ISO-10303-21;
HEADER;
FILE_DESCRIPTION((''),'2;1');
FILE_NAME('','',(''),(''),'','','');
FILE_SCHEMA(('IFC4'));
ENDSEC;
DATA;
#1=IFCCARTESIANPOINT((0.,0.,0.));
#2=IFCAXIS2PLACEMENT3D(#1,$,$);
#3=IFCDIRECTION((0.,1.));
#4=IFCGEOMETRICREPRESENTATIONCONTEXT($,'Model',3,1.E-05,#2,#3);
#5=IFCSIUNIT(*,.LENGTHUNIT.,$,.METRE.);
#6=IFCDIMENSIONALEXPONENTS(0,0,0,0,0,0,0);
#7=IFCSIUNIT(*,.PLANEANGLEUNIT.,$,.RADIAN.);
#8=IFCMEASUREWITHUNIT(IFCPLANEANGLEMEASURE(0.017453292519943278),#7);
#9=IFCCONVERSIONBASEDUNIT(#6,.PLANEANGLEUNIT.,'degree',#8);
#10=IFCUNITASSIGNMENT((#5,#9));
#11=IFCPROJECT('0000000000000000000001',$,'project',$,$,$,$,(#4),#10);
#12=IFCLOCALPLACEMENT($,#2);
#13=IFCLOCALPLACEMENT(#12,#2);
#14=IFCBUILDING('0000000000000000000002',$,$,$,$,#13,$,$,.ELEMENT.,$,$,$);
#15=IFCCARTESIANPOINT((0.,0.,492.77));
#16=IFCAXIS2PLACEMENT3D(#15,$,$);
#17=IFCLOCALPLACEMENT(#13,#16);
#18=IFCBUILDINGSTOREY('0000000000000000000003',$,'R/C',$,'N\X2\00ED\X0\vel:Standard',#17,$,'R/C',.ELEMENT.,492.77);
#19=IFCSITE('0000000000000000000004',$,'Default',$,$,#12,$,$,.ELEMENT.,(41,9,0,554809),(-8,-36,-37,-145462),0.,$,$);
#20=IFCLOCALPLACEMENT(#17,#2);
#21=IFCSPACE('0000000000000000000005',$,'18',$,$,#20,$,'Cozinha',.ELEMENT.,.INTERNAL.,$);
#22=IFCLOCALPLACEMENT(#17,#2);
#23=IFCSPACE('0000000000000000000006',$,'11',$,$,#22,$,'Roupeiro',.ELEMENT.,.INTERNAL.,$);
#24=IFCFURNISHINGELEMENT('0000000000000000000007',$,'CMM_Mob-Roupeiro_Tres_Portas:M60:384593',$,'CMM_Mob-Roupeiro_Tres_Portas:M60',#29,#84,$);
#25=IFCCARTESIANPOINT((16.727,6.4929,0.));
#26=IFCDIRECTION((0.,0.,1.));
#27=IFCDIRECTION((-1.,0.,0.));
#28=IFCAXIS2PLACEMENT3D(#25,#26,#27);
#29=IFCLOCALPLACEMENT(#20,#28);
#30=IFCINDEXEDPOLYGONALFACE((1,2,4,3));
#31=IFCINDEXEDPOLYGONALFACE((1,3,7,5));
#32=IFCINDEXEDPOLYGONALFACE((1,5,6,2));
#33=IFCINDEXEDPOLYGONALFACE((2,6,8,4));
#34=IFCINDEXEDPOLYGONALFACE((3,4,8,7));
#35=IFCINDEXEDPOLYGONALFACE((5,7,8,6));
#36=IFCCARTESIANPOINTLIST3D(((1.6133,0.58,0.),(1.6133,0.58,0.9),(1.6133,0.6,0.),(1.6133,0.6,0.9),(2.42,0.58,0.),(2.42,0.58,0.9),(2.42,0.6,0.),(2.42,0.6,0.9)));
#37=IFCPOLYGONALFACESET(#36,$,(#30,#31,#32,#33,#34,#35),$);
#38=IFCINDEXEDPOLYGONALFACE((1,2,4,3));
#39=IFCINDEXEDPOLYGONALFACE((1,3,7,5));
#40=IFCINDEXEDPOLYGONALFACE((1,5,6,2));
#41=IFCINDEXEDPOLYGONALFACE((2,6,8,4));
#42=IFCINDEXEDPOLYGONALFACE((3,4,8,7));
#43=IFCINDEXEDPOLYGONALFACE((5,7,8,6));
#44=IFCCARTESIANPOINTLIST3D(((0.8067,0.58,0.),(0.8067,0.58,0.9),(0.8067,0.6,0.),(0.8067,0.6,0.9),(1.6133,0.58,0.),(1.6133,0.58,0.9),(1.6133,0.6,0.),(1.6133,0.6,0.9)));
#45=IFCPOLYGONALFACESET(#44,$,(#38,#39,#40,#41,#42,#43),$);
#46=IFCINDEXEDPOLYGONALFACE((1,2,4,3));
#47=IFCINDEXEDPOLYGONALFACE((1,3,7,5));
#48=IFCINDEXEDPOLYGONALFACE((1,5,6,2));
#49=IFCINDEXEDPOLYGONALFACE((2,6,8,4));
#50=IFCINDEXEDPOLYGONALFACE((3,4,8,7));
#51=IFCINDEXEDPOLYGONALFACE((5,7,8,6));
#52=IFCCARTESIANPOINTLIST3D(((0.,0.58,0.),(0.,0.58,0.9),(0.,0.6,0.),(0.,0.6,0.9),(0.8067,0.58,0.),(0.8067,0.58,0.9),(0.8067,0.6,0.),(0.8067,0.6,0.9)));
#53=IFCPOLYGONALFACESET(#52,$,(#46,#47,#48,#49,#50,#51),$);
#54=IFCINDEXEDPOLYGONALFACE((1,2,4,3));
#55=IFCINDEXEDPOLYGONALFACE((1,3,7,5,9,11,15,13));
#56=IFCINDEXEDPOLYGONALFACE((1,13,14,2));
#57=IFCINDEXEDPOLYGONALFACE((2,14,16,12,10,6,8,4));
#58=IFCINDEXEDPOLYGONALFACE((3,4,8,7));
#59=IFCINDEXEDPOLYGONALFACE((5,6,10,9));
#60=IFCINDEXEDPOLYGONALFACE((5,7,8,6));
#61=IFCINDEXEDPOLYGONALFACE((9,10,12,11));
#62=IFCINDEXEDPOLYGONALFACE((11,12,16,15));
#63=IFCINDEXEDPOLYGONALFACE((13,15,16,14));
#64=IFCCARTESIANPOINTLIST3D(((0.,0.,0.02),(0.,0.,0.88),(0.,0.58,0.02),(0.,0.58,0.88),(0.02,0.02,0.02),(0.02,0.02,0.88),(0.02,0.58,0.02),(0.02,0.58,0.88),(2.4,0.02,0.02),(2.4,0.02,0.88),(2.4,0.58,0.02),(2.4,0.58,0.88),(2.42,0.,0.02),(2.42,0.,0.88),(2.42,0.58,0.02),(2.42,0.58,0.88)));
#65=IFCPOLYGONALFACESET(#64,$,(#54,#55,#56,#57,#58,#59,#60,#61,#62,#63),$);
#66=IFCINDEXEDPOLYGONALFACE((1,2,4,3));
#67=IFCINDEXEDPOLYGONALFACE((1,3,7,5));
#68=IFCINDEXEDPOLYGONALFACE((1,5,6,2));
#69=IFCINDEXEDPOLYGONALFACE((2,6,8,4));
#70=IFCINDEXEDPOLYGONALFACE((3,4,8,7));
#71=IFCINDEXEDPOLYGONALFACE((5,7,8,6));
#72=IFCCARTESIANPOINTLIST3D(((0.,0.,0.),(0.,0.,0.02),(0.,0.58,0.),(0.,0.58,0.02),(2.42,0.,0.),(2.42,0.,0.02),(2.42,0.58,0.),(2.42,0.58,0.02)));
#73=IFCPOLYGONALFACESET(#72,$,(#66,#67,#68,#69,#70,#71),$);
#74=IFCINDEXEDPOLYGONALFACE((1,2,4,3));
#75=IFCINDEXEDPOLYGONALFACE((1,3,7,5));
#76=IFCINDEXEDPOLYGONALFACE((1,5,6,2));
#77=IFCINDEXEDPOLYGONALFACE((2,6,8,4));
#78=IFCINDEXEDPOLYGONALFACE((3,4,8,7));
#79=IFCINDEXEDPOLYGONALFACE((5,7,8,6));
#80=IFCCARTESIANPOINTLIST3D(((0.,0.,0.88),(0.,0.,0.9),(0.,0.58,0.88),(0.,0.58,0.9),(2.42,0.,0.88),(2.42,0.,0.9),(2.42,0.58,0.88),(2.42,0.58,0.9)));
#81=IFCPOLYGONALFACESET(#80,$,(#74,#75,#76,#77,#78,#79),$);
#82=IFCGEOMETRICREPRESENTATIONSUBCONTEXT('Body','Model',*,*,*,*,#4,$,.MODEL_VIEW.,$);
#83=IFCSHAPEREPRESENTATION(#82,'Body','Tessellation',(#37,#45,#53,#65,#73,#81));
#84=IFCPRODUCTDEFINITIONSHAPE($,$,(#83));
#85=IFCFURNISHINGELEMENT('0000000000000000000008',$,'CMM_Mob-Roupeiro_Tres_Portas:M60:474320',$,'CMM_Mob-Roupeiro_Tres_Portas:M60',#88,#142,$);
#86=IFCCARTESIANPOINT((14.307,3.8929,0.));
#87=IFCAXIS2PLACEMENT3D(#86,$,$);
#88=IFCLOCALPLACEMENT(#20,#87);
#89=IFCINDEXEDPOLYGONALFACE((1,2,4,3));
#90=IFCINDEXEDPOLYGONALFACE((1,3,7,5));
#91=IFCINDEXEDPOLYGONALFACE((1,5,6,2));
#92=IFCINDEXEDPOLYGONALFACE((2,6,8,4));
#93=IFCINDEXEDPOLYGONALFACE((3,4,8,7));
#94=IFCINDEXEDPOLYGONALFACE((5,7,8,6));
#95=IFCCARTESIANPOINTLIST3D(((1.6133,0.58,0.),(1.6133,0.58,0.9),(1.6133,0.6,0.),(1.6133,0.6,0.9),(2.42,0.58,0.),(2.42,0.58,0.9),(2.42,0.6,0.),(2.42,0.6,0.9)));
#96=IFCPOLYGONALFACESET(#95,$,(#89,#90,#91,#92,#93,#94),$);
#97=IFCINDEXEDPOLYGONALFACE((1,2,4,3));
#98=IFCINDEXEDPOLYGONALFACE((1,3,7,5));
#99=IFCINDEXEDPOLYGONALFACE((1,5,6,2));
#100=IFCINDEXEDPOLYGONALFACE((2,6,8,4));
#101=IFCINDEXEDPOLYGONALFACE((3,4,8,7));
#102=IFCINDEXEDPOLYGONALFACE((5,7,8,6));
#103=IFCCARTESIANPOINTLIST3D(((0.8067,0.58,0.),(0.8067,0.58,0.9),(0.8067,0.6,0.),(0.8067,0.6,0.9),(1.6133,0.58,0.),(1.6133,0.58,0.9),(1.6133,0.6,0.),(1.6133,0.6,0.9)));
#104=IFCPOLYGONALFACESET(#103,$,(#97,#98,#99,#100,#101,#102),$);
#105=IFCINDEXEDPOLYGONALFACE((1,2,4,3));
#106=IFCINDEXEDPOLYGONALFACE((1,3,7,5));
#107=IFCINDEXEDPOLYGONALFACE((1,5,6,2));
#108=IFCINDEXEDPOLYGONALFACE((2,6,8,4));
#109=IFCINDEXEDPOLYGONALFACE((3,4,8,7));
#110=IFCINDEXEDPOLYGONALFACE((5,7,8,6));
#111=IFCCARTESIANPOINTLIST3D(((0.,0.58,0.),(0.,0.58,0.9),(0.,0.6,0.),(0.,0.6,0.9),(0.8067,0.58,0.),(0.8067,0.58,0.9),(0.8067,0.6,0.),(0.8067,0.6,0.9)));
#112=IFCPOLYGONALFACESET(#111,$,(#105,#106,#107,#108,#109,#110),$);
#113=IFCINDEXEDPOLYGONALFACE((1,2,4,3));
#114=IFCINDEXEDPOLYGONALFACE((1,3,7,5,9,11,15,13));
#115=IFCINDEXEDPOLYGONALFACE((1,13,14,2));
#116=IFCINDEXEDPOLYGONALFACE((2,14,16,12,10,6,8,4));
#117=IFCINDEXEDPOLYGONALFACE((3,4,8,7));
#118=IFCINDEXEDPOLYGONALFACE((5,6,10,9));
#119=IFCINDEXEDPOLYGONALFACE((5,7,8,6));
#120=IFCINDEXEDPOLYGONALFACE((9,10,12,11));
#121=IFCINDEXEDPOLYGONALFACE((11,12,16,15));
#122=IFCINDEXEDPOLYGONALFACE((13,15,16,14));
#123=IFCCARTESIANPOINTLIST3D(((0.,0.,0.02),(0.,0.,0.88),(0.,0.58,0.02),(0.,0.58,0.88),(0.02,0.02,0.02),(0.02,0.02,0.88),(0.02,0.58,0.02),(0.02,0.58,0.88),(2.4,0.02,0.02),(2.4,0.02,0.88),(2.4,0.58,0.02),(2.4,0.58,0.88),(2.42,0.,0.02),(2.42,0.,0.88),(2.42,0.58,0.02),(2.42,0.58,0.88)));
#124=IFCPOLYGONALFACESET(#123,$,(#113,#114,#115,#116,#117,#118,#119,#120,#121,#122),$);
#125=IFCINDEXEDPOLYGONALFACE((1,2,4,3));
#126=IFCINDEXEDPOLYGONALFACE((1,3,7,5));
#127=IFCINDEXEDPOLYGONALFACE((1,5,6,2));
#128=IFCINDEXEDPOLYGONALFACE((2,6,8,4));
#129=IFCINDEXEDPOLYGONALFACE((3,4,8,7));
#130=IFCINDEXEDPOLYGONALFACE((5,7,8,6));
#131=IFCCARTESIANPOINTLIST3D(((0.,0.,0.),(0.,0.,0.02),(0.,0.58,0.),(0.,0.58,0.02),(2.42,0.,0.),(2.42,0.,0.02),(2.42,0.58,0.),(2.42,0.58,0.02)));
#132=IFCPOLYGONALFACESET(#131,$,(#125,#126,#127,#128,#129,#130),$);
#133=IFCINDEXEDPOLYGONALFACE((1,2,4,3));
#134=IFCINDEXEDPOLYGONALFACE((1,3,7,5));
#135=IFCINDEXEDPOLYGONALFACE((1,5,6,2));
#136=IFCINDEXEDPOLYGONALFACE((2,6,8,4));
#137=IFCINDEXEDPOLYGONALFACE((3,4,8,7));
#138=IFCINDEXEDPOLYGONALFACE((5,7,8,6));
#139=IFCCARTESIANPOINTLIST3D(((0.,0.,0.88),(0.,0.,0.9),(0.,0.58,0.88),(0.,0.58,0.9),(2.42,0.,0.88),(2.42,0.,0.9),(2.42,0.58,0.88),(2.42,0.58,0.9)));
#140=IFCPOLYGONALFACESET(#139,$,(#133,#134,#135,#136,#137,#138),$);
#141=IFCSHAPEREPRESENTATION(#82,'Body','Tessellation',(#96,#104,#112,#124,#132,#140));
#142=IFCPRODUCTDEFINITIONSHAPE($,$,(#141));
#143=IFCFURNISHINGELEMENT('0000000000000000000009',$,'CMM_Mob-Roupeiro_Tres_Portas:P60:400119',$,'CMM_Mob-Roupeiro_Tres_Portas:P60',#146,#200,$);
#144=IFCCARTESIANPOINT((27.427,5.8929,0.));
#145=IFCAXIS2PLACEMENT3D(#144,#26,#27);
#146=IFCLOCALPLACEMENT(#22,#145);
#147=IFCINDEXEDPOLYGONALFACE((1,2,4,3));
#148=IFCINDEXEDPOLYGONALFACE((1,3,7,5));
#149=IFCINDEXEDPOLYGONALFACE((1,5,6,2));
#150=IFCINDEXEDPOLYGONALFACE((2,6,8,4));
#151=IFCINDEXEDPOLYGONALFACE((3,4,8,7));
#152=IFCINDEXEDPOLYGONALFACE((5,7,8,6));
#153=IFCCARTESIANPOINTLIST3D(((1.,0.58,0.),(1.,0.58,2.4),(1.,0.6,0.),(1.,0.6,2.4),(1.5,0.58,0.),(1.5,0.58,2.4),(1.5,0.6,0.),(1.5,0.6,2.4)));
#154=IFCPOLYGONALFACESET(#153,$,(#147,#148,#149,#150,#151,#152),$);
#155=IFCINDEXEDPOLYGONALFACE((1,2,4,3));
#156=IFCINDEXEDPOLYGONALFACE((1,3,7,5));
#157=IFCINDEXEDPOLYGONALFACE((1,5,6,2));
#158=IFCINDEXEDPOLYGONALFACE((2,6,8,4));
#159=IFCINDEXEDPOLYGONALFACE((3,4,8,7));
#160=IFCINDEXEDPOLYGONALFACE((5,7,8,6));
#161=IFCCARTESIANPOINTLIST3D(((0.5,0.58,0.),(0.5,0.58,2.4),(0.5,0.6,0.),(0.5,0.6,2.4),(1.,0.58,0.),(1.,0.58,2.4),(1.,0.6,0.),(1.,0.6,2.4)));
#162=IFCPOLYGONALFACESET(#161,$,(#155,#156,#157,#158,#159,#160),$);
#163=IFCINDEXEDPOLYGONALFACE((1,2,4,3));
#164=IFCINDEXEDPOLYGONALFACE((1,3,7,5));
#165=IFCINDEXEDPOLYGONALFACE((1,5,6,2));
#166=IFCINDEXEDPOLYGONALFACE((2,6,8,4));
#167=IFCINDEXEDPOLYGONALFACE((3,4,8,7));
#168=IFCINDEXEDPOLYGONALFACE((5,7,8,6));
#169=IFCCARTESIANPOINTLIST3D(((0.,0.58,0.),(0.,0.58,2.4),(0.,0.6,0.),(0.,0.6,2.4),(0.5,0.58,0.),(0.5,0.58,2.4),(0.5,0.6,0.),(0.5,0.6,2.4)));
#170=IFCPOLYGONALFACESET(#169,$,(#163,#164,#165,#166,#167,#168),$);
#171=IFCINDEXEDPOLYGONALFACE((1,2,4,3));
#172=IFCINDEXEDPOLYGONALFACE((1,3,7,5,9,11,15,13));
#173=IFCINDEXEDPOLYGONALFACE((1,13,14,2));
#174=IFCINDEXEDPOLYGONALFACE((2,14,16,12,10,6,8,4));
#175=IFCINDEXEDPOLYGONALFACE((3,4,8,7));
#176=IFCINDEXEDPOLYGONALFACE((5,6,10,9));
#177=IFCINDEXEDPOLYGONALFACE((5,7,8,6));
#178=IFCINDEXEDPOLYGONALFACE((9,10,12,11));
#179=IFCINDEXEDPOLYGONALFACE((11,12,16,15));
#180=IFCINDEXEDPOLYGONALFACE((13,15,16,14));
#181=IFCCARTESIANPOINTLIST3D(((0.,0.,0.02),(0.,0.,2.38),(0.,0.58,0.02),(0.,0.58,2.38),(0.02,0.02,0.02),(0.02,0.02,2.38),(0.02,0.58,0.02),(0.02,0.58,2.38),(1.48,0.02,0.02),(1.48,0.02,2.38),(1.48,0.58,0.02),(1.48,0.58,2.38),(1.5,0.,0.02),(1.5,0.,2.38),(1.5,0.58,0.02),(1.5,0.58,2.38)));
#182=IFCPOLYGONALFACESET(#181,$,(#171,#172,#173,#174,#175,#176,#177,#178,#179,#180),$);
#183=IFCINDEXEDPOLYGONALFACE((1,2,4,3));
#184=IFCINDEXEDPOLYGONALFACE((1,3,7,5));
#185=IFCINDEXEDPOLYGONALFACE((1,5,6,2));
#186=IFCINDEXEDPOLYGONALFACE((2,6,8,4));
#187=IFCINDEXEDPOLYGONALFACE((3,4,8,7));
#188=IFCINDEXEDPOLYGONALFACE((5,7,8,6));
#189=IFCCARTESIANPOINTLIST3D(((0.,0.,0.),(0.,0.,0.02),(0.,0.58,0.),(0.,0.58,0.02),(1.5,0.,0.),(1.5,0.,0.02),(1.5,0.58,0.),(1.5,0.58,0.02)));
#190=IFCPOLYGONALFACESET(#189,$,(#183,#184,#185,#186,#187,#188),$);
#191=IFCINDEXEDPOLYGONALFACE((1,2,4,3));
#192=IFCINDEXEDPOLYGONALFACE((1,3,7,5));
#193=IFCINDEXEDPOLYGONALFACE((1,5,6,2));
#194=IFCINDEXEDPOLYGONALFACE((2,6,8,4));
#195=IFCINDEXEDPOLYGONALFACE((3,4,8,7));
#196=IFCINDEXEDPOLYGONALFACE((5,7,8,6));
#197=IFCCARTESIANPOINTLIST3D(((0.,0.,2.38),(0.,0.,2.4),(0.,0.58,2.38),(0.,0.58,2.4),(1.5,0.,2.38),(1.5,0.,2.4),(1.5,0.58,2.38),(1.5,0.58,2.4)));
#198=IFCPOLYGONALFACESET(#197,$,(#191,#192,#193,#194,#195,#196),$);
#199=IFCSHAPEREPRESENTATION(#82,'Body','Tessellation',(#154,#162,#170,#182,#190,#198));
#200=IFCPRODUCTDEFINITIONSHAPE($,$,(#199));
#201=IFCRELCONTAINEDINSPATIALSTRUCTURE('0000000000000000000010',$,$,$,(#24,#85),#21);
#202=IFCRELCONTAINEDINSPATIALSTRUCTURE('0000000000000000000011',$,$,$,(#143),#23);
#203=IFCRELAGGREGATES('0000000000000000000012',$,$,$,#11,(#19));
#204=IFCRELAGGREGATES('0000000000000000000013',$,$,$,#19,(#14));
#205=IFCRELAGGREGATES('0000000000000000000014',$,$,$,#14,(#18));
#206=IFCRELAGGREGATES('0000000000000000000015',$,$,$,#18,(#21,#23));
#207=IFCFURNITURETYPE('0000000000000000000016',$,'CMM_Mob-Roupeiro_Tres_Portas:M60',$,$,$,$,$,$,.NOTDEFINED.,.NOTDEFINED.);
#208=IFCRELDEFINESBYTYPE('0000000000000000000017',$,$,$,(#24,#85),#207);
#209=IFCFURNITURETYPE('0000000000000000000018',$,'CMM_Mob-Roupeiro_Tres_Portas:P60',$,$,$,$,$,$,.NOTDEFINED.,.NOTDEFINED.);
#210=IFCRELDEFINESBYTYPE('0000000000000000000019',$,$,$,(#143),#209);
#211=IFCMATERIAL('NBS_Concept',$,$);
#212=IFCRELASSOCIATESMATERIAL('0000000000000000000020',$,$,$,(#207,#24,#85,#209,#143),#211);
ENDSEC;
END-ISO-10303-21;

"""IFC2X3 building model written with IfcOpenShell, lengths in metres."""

from ifc_helpers import new_model, entity, si_unit, converted_unit, direction, frame, frame_2d, origin, place, context, subcontext, project, spatial, polyline, rectangle, outline, extrude, source, transform, mapped, material, type_object, type_shapes, element, save


model = new_model("IFC2X3")

# Units and contexts
model_context = context("Model", 3, precision=1e-05, world=origin(), true_north=direction((0.0, 1.0)))
body_context = subcontext(model_context, "Body", "Model", "MODEL_VIEW")
ifc_project = project(units=[si_unit("LENGTHUNIT", "METRE"), converted_unit("PLANEANGLEUNIT", "degree", entity("IfcPlaneAngleMeasure", 0.017453292519943278), si_unit("PLANEANGLEUNIT", "RADIAN"), dimensions=[0, 0, 0, 0, 0, 0, 0])], contexts=[model_context])

# Site, building, storey
site_placement = place(None, origin())
site = spatial("IfcSite", under=ifc_project, at=site_placement, Name="Default", CompositionType="ELEMENT", RefLatitude=(41, 9, 0, 554809), RefLongitude=(-8, -36, -37, -145462), RefElevation=0.0)
building_placement = place(site_placement, origin())
building = spatial("IfcBuilding", under=site, at=building_placement, CompositionType="ELEMENT")
storey_placement = place(building_placement, frame((0.0, 0.0, 492.77)))
storey = spatial("IfcBuildingStorey", under=building, at=storey_placement, Name="R/C", ObjectType="Nível:Standard", LongName="R/C", CompositionType="ELEMENT", Elevation=492.77)

# Shared definitions
space_1_placement = place(storey_placement, origin())
space_1 = spatial("IfcSpace", under=storey, at=space_1_placement, Name="18", LongName="Cozinha", CompositionType="ELEMENT", InteriorOrExteriorSpace="INTERNAL")

# Furnishing elements
ifc_material_1 = material(Name="NBS_Concept")
furniture_type_1 = type_object("IfcFurnitureType", Name="CMM_Mob-Roupeiro_Tres_Portas:M60", AssemblyPlace="NOTDEFINED", material=ifc_material_1)
shared_shape_1 = source(origin(), body_context, "Body", "SweptSolid", [
    extrude(rectangle(XDim=0.8067, YDim=0.02, at=frame_2d((0.0, 0.0), x_axis=(1.0, 0.0))), frame((2.0167, 0.59, 0.0), z_axis=(0.0, 0.0, 1.0), x_axis=(-1.0, 0.0, 0.0)), (0.0, 0.0, 1.0), 0.9),
    extrude(rectangle(XDim=0.8067, YDim=0.02, at=frame_2d((0.0, 0.0), x_axis=(1.0, 0.0))), frame((1.21, 0.59, 0.0), z_axis=(0.0, 0.0, 1.0), x_axis=(-1.0, 0.0, 0.0)), (0.0, 0.0, 1.0), 0.9),
    extrude(rectangle(XDim=0.8067, YDim=0.02, at=frame_2d((0.0, 0.0), x_axis=(1.0, 0.0))), frame((0.4033, 0.59, 0.0), z_axis=(0.0, 0.0, 1.0), x_axis=(-1.0, 0.0, 0.0)), (0.0, 0.0, 1.0), 0.9),
    extrude(outline(polyline([(-1.21, -0.295), (1.21, -0.295), (1.21, 0.285), (1.19, 0.285), (1.19, -0.275), (-1.19, -0.275), (-1.19, 0.285), (-1.21, 0.285), (-1.21, -0.295)])), frame((1.21, 0.295, 0.02)), (0.0, 0.0, 1.0), 0.86),
    extrude(rectangle(XDim=2.42, YDim=0.58, at=frame_2d((0.0, 0.0), x_axis=(1.0, 0.0))), frame((1.21, 0.29, 0.0), z_axis=(0.0, 0.0, 1.0), x_axis=(-1.0, 0.0, 0.0)), (0.0, 0.0, 1.0), 0.02),
    extrude(rectangle(XDim=2.42, YDim=0.58, at=frame_2d((0.0, 0.0), x_axis=(1.0, 0.0))), frame((1.21, 0.29, 0.88), z_axis=(0.0, 0.0, 1.0), x_axis=(-1.0, 0.0, 0.0)), (0.0, 0.0, 1.0), 0.02),
])
type_shapes(furniture_type_1, [shared_shape_1])
furnishing_1_placement = place(space_1_placement, frame((16.727, 6.4929, 0.0), z_axis=(0.0, 0.0, 1.0), x_axis=(-1.0, 0.0, 0.0)))
element("IfcFurnishingElement", 1, at=furnishing_1_placement, inside=space_1, type_object=furniture_type_1, material=ifc_material_1, Name="CMM_Mob-Roupeiro_Tres_Portas:M60:384593", ObjectType="CMM_Mob-Roupeiro_Tres_Portas:M60", context=body_context, shape_type="MappedRepresentation", body=[
    mapped(shared_shape_1, transform((0.0, 0.0, 0.0), scale=1.0)),
])
furnishing_2_placement = place(space_1_placement, frame((14.307, 3.8929, 0.0)))
element("IfcFurnishingElement", 2, at=furnishing_2_placement, inside=space_1, type_object=furniture_type_1, material=ifc_material_1, Name="CMM_Mob-Roupeiro_Tres_Portas:M60:474320", ObjectType="CMM_Mob-Roupeiro_Tres_Portas:M60", context=body_context, shape_type="MappedRepresentation", body=[
    mapped(shared_shape_1, transform((0.0, 0.0, 0.0), scale=1.0)),
])

# Shared definitions
space_2_placement = place(storey_placement, origin())
space_2 = spatial("IfcSpace", under=storey, at=space_2_placement, Name="11", LongName="Roupeiro", CompositionType="ELEMENT", InteriorOrExteriorSpace="INTERNAL")

# Furnishing element
furniture_type_2 = type_object("IfcFurnitureType", Name="CMM_Mob-Roupeiro_Tres_Portas:P60", AssemblyPlace="NOTDEFINED", material=ifc_material_1)
shared_shape_2 = source(origin(), body_context, "Body", "SweptSolid", [
    extrude(rectangle(XDim=0.5, YDim=0.02, at=frame_2d((0.0, 0.0), x_axis=(1.0, 0.0))), frame((1.25, 0.59, 0.0), z_axis=(0.0, 0.0, 1.0), x_axis=(-1.0, 0.0, 0.0)), (0.0, 0.0, 1.0), 2.4),
    extrude(rectangle(XDim=0.5, YDim=0.02, at=frame_2d((0.0, 0.0), x_axis=(1.0, 0.0))), frame((0.75, 0.59, 0.0), z_axis=(0.0, 0.0, 1.0), x_axis=(-1.0, 0.0, 0.0)), (0.0, 0.0, 1.0), 2.4),
    extrude(rectangle(XDim=0.5, YDim=0.02, at=frame_2d((0.0, 0.0), x_axis=(1.0, 0.0))), frame((0.25, 0.59, 0.0), z_axis=(0.0, 0.0, 1.0), x_axis=(-1.0, 0.0, 0.0)), (0.0, 0.0, 1.0), 2.4),
    extrude(outline(polyline([(-0.75, -0.295), (0.75, -0.295), (0.75, 0.285), (0.73, 0.285), (0.73, -0.275), (-0.73, -0.275), (-0.73, 0.285), (-0.75, 0.285), (-0.75, -0.295)])), frame((0.75, 0.295, 0.02)), (0.0, 0.0, 1.0), 2.36),
    extrude(rectangle(XDim=1.5, YDim=0.58, at=frame_2d((0.0, 0.0), x_axis=(1.0, 0.0))), frame((0.75, 0.29, 0.0), z_axis=(0.0, 0.0, 1.0), x_axis=(-1.0, 0.0, 0.0)), (0.0, 0.0, 1.0), 0.02),
    extrude(rectangle(XDim=1.5, YDim=0.58, at=frame_2d((0.0, 0.0), x_axis=(1.0, 0.0))), frame((0.75, 0.29, 2.38), z_axis=(0.0, 0.0, 1.0), x_axis=(-1.0, 0.0, 0.0)), (0.0, 0.0, 1.0), 0.02),
])
type_shapes(furniture_type_2, [shared_shape_2])
furnishing_3_placement = place(space_2_placement, frame((27.427, 5.8929, 0.0), z_axis=(0.0, 0.0, 1.0), x_axis=(-1.0, 0.0, 0.0)))
element("IfcFurnishingElement", 3, at=furnishing_3_placement, inside=space_2, type_object=furniture_type_2, material=ifc_material_1, Name="CMM_Mob-Roupeiro_Tres_Portas:P60:400119", ObjectType="CMM_Mob-Roupeiro_Tres_Portas:P60", context=body_context, shape_type="MappedRepresentation", body=[
    mapped(shared_shape_2, transform((0.0, 0.0, 0.0), scale=1.0)),
])

save(model, "model.ifc")
